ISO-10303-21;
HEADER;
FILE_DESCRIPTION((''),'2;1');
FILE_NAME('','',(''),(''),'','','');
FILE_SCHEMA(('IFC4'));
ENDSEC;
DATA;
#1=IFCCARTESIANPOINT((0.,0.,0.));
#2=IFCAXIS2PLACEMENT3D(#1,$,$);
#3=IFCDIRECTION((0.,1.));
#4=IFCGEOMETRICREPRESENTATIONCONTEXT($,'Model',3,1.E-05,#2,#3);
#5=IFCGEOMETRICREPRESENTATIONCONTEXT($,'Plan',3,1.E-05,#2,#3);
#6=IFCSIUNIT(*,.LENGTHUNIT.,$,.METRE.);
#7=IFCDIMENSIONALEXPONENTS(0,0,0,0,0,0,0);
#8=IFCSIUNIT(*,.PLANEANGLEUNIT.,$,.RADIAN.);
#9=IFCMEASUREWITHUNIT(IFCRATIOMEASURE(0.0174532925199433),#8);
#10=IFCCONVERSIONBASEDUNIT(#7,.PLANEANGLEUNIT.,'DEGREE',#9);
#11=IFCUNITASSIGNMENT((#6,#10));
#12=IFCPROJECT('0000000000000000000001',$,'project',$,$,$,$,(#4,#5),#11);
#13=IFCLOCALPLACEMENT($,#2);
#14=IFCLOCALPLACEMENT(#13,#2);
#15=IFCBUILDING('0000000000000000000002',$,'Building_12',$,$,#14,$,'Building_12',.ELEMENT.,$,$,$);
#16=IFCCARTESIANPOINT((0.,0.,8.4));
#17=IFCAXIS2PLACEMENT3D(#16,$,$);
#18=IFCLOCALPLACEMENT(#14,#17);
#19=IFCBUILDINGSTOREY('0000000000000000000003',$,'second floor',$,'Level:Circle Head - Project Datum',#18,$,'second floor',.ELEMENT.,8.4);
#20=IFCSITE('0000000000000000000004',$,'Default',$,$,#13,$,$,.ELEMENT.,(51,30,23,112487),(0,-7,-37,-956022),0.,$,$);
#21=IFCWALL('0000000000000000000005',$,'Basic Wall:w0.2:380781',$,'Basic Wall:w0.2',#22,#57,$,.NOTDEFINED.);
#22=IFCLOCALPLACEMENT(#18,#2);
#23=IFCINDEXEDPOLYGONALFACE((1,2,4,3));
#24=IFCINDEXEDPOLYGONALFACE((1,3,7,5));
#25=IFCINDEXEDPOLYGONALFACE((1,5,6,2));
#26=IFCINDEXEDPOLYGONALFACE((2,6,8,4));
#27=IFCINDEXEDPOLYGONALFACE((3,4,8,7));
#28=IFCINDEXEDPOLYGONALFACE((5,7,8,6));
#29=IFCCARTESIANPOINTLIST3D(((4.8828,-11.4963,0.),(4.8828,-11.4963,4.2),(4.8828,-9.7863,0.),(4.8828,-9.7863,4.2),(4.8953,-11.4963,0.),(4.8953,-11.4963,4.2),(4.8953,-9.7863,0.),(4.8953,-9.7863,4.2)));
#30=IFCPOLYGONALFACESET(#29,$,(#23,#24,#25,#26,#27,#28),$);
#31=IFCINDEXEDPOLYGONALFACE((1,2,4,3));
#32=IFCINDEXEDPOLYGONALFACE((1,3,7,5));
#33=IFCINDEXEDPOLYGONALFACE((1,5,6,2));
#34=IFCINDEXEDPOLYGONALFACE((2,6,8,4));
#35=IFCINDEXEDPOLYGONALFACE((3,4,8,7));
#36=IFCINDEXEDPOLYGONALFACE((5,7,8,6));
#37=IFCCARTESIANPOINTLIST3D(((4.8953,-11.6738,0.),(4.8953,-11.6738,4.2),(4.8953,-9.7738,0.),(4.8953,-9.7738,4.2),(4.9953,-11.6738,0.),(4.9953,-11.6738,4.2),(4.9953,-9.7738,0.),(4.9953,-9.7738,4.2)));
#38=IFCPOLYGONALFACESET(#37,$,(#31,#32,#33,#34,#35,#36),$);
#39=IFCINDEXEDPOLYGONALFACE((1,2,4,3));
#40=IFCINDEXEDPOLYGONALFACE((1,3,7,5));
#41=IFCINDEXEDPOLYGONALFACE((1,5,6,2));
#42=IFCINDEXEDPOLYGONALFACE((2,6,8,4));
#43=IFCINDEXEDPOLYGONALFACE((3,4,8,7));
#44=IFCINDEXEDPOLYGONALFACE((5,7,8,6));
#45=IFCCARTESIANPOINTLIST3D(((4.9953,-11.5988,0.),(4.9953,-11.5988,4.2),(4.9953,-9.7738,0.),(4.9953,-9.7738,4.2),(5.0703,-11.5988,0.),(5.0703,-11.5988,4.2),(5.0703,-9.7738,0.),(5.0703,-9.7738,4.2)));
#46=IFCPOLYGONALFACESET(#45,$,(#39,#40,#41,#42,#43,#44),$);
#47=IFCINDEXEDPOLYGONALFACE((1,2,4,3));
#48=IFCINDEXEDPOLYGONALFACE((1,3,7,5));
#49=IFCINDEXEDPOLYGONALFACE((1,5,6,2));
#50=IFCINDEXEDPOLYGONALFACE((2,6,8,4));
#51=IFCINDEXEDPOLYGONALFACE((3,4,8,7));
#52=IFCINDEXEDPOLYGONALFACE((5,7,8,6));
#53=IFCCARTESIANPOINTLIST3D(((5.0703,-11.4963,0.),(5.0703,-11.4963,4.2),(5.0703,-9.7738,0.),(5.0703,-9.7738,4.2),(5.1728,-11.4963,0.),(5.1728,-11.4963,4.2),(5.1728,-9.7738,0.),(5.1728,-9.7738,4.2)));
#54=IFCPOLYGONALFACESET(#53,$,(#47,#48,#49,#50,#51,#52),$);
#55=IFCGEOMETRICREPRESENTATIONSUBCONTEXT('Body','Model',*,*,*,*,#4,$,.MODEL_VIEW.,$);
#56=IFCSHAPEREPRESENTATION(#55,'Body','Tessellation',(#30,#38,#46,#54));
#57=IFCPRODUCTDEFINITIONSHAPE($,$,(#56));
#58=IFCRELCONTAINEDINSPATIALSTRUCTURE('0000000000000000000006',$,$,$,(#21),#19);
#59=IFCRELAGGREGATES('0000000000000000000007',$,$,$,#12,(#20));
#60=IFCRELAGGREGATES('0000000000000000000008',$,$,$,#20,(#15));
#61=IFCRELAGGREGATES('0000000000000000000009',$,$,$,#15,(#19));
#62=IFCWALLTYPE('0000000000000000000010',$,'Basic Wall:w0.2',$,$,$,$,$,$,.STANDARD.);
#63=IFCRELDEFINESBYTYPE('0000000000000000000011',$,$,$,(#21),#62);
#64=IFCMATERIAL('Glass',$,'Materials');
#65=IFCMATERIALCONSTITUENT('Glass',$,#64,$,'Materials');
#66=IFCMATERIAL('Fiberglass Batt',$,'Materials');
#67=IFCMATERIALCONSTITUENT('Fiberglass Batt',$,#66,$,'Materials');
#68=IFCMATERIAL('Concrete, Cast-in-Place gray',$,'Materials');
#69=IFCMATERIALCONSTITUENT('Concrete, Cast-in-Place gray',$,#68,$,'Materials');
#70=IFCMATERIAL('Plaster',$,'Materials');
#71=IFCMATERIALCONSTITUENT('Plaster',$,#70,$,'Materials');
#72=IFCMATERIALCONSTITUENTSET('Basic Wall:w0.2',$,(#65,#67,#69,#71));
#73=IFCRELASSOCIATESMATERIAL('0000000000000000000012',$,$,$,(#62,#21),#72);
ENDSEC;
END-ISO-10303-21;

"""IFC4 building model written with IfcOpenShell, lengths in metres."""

from ifc_helpers import new_model, entity, si_unit, converted_unit, direction, frame, origin, place, context, subcontext, project, spatial, indexed_curve, outline, extrude, material, constituent, constituent_set, type_object, element, save


model = new_model("IFC4")

# Units and contexts
model_context = context("Model", 3, precision=1e-05, world=origin(), true_north=direction((0.0, 1.0)))
plan_context = context("Plan", 3, precision=1e-05, world=origin(), true_north=direction((0.0, 1.0)))
body_context = subcontext(model_context, "Body", "Model", "MODEL_VIEW")
ifc_project = project(units=[si_unit("LENGTHUNIT", "METRE"), converted_unit("PLANEANGLEUNIT", "DEGREE", entity("IfcRatioMeasure", 0.0174532925199433), si_unit("PLANEANGLEUNIT", "RADIAN"), dimensions=[0, 0, 0, 0, 0, 0, 0])], contexts=[model_context, plan_context])

# Site, building, storey
site_placement = place(None, origin())
site = spatial("IfcSite", under=ifc_project, at=site_placement, Name="Default", CompositionType="ELEMENT", RefLatitude=(51, 30, 23, 112487), RefLongitude=(0, -7, -37, -956022), RefElevation=0.0)
building_placement = place(site_placement, origin())
building = spatial("IfcBuilding", under=site, at=building_placement, Name="Building_12", LongName="Building_12", CompositionType="ELEMENT")
storey_placement = place(building_placement, frame((0.0, 0.0, 8.4)))
storey = spatial("IfcBuildingStorey", under=building, at=storey_placement, Name="second floor", ObjectType="Level:Circle Head - Project Datum", LongName="second floor", CompositionType="ELEMENT", Elevation=8.4)

# Shared definitions
ifc_material_1 = material(Name="Glass", Category="Materials")
ifc_constituent_1 = constituent(ifc_material_1, Name="Glass", Category="Materials")
ifc_material_2 = material(Name="Fiberglass Batt", Category="Materials")
ifc_constituent_2 = constituent(ifc_material_2, Name="Fiberglass Batt", Category="Materials")
ifc_material_3 = material(Name="Concrete, Cast-in-Place gray", Category="Materials")
ifc_constituent_3 = constituent(ifc_material_3, Name="Concrete, Cast-in-Place gray", Category="Materials")
ifc_material_4 = material(Name="Plaster", Category="Materials")
ifc_constituent_4 = constituent(ifc_material_4, Name="Plaster", Category="Materials")
ifc_constituent_set = constituent_set(constituents=[ifc_constituent_1, ifc_constituent_2, ifc_constituent_3, ifc_constituent_4], Name="Basic Wall:w0.2")
wall_type = type_object("IfcWallType", Name="Basic Wall:w0.2", PredefinedType="STANDARD", material=ifc_constituent_set)

# Wall
wall_1_placement = place(storey_placement, frame((5.0278, -9.7863, 0.0), z_axis=(0.0, 0.0, 1.0), x_axis=(0.0, -1.0, 0.0)))
element("IfcWall", 1, at=wall_1_placement, inside=storey, type_object=wall_type, material=ifc_constituent_set, Name="Basic Wall:w0.2:380781", ObjectType="Basic Wall:w0.2", PredefinedType="NOTDEFINED", context=body_context, shape_type="SweptSolid", body=[
    extrude(outline(indexed_curve([(-0.0063, -0.855), (0.0062, -0.855), (0.0063, 0.855), (-0.0062, 0.855), (-0.0063, -0.855)], self_intersect=False)), frame((0.855, -0.1388, 0.0), z_axis=(0.0, 0.0, 1.0), x_axis=(0.0, 1.0, 0.0)), (0.0, 0.0, 1.0), 4.2),
    extrude(outline(indexed_curve([(-0.95, -0.05), (0.95, -0.05), (0.95, 0.05), (-0.95, 0.05), (-0.95, -0.05)], self_intersect=False)), frame((0.9375, -0.0825, 0.0)), (0.0, 0.0, 1.0), 4.2),
    extrude(outline(indexed_curve([(-0.9125, -0.0375), (0.9125, -0.0375), (0.9125, 0.0375), (-0.9125, 0.0375), (-0.9125, -0.0375)], self_intersect=False)), frame((0.9, 0.005, 0.0)), (0.0, 0.0, 1.0), 4.2),
    extrude(outline(indexed_curve([(-0.0513, -0.8612), (0.0512, -0.8612), (0.0513, 0.8613), (-0.0512, 0.8613), (-0.0513, -0.8612)], self_intersect=False)), frame((0.8488, 0.0937, 0.0), z_axis=(0.0, 0.0, 1.0), x_axis=(0.0, -1.0, 0.0)), (0.0, 0.0, 1.0), 4.2),
])

save(model, "model.ifc")
